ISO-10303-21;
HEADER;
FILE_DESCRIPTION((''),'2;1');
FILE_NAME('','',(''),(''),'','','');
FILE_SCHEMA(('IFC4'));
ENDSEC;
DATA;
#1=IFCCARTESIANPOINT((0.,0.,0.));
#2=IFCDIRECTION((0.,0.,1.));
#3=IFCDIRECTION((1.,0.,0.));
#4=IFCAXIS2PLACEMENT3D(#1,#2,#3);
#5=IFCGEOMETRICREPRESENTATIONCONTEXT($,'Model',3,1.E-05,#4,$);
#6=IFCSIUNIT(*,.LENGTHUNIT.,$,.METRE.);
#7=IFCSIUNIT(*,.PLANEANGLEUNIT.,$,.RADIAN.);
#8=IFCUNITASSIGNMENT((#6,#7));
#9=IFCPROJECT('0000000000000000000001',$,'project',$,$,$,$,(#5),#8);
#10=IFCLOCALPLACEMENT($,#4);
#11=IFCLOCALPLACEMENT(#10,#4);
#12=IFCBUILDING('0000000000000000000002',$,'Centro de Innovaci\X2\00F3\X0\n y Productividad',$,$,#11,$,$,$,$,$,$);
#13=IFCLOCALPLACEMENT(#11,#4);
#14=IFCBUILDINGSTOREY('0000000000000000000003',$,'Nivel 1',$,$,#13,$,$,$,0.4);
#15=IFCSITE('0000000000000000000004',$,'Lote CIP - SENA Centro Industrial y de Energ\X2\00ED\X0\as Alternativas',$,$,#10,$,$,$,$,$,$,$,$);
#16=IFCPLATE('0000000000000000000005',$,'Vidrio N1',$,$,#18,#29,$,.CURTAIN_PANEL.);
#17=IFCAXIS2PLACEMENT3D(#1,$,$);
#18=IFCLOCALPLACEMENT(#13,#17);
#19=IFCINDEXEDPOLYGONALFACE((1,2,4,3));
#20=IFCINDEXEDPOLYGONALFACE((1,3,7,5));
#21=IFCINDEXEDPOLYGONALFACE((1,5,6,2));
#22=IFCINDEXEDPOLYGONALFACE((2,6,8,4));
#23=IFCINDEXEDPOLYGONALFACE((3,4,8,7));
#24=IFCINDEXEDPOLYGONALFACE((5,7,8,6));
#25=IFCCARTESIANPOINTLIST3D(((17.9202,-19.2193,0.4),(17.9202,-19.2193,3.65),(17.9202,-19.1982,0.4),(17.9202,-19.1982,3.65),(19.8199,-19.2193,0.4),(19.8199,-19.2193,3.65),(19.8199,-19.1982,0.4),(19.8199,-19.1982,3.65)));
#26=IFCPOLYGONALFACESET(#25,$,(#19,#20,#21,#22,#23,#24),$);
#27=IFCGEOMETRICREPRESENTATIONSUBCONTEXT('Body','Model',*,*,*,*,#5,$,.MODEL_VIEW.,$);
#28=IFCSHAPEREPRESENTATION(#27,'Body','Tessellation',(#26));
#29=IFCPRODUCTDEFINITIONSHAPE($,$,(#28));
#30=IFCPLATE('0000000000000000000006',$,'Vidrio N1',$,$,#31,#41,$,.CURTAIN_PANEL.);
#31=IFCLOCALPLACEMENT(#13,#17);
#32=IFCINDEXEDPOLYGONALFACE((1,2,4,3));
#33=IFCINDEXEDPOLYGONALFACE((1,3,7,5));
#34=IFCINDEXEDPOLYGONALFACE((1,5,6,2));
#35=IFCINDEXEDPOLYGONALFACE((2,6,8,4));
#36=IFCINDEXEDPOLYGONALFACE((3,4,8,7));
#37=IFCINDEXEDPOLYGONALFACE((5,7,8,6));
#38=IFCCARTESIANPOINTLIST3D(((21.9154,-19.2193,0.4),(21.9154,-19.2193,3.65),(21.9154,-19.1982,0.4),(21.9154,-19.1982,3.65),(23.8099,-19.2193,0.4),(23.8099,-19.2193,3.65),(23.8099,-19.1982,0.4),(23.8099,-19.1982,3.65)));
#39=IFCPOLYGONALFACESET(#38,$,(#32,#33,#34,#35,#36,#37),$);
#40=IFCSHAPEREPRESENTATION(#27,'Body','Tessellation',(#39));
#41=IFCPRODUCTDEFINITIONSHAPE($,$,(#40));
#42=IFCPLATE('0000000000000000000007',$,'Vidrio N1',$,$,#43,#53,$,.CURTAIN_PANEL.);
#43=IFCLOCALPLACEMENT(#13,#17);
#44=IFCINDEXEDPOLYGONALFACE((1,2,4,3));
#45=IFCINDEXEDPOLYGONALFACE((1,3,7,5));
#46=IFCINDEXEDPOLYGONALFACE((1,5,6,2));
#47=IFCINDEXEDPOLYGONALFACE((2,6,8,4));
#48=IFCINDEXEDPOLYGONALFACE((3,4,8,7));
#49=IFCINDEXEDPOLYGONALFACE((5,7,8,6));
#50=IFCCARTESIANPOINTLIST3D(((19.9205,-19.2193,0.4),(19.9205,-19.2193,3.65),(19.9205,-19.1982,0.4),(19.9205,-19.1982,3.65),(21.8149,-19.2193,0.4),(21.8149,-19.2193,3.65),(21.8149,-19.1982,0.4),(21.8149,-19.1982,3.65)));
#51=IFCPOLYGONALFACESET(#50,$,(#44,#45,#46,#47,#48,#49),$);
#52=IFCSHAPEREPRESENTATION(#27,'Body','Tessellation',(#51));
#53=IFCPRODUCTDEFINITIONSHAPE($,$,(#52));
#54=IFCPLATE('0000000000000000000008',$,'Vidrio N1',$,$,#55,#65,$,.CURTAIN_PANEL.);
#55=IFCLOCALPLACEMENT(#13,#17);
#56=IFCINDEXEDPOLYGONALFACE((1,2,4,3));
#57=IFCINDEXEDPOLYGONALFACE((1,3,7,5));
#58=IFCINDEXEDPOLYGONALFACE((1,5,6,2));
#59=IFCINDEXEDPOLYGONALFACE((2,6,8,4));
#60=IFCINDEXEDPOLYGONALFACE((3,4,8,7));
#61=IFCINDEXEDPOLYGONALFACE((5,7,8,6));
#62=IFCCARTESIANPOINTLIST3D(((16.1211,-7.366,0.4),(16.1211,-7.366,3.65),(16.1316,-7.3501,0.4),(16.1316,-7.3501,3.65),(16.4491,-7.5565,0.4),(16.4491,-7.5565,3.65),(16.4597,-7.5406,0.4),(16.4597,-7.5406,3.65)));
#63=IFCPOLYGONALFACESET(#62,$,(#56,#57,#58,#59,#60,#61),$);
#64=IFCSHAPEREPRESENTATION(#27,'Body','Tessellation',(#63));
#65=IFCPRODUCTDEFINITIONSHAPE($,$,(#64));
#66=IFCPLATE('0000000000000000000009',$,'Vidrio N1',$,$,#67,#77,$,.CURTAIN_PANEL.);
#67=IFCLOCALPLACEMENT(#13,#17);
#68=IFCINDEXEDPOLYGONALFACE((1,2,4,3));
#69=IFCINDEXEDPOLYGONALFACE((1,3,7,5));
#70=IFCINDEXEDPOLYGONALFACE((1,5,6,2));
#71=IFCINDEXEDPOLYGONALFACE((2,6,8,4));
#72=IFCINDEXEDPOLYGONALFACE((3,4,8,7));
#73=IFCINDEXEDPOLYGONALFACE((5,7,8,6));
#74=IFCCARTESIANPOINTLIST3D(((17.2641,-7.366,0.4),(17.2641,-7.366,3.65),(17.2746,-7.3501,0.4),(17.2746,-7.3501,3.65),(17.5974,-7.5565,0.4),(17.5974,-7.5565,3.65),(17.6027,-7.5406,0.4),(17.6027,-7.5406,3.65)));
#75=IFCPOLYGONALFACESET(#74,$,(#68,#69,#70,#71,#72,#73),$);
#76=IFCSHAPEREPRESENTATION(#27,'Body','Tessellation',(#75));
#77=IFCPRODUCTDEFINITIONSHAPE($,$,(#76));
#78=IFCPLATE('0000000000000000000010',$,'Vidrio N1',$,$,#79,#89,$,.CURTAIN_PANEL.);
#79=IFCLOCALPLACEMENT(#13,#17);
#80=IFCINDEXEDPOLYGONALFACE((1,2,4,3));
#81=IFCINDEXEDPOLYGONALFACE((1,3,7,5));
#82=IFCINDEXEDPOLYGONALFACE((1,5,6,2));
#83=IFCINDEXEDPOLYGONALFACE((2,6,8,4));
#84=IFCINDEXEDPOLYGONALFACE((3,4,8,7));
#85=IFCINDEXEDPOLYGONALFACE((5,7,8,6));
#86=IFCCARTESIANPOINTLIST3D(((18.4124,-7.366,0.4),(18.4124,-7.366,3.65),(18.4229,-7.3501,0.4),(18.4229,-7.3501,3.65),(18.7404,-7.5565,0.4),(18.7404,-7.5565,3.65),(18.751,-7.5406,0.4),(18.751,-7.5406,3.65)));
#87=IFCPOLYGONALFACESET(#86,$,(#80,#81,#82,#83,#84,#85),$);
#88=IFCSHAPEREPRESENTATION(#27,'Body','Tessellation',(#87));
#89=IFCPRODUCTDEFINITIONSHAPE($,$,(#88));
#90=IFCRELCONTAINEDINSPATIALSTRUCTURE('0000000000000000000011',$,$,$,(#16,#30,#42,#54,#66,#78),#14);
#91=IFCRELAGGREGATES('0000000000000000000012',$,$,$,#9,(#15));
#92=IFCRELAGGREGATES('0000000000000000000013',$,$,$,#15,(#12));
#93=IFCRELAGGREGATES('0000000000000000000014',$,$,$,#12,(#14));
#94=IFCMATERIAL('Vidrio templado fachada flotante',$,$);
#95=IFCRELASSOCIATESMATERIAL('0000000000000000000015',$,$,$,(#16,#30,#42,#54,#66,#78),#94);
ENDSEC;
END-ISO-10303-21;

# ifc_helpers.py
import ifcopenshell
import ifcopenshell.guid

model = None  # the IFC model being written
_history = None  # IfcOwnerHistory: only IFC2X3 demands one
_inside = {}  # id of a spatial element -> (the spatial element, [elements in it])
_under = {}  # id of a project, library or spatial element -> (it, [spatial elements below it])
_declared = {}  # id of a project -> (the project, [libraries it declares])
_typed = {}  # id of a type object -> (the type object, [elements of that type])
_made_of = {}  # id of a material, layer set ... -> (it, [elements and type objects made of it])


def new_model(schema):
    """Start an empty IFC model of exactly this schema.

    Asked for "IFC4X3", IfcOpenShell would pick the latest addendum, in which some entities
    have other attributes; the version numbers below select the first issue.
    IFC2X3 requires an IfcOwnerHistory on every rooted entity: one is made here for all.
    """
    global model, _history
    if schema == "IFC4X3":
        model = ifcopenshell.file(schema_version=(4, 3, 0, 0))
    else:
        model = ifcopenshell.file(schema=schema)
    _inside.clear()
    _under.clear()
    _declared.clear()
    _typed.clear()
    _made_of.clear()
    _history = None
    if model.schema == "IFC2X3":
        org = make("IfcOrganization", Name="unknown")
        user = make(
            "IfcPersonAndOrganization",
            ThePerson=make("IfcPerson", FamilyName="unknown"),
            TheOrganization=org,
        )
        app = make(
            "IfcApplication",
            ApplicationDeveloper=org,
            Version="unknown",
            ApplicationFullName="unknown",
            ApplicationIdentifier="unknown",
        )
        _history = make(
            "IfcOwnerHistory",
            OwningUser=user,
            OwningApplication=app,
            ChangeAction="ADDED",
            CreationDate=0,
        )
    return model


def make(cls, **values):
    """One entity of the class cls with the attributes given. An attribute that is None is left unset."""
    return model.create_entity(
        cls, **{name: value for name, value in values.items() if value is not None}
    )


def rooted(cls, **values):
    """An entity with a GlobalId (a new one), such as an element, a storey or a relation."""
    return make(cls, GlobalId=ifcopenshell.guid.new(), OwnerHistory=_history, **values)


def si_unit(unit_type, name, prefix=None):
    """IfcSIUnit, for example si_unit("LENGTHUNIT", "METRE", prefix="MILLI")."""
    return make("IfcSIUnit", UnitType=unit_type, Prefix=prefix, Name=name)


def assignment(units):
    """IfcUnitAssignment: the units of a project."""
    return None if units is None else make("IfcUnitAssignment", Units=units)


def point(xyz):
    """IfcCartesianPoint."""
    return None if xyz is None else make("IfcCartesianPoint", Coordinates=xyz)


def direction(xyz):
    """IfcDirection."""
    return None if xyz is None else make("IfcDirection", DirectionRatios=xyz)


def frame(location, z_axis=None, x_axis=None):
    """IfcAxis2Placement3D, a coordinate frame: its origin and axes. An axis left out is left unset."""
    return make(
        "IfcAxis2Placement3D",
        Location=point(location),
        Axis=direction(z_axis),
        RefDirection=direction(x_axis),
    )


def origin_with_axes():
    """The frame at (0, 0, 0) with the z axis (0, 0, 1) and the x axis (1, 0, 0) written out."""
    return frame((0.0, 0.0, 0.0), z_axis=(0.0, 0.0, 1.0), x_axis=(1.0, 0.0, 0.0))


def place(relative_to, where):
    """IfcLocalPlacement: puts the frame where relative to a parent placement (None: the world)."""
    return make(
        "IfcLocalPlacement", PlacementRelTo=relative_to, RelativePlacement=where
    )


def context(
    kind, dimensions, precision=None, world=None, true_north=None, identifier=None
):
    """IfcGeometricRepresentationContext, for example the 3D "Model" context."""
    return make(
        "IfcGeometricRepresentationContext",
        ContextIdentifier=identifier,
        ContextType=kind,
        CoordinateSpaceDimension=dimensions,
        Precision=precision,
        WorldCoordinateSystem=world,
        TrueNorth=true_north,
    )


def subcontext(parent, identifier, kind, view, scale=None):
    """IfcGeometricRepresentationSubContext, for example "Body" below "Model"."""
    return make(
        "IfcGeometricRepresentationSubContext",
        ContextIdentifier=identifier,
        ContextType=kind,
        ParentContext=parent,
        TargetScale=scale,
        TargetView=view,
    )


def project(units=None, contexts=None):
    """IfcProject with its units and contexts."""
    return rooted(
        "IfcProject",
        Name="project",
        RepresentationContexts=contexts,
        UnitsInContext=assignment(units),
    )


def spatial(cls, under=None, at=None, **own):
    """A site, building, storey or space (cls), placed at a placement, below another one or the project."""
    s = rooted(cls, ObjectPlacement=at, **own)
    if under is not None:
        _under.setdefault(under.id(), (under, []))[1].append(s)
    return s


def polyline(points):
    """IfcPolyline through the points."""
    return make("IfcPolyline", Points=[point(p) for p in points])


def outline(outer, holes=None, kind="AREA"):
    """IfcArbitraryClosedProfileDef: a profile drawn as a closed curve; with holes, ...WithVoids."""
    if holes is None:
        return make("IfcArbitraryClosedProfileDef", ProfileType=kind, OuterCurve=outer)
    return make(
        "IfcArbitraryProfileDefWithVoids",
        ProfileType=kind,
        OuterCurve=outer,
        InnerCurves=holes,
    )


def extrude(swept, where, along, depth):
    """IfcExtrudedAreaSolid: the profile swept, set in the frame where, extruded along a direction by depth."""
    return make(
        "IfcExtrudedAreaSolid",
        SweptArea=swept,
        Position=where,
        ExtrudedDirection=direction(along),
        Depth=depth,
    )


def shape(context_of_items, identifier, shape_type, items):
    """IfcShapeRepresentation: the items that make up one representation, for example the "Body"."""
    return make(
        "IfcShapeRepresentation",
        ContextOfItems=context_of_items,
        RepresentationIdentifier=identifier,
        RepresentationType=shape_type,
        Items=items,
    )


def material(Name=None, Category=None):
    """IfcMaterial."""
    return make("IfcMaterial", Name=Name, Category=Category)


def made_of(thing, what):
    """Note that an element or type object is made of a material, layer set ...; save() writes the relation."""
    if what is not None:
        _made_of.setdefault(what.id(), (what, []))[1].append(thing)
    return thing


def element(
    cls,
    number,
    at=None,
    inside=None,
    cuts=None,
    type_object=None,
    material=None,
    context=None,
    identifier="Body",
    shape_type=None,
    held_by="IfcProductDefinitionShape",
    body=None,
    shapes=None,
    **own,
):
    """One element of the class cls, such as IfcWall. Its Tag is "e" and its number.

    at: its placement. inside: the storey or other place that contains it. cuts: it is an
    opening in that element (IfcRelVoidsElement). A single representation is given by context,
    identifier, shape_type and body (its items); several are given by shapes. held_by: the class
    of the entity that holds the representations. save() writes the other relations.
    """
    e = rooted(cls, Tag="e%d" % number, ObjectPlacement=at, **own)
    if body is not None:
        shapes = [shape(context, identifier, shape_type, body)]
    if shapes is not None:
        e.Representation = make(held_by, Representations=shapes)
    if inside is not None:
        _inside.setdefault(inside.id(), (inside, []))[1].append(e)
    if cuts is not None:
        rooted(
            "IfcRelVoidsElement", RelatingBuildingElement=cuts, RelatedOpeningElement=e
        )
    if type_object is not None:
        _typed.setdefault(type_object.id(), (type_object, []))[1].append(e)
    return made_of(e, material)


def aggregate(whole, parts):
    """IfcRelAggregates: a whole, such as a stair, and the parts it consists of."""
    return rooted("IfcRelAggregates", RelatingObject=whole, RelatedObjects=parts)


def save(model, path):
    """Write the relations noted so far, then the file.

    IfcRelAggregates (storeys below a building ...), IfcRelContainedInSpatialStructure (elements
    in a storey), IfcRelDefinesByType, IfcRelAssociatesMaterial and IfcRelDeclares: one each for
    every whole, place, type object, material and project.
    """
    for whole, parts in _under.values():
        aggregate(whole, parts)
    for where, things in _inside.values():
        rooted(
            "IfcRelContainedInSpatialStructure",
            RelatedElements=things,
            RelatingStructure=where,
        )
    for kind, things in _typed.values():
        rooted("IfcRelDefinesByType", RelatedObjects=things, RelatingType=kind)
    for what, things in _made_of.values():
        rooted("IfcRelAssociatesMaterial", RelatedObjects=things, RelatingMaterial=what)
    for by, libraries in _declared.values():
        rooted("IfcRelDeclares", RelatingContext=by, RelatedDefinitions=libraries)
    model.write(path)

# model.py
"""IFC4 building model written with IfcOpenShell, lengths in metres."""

from ifc_helpers import new_model, si_unit, frame, origin_with_axes, place, context, subcontext, project, spatial, polyline, outline, extrude, material, element, save


model = new_model("IFC4")

# Units and contexts
model_context = context("Model", 3, precision=1e-05, world=origin_with_axes())
body_context = subcontext(model_context, "Body", "Model", "MODEL_VIEW")
ifc_project = project(units=[si_unit("LENGTHUNIT", "METRE"), si_unit("PLANEANGLEUNIT", "RADIAN")], contexts=[model_context])

# Site, building, storey
site_placement = place(None, origin_with_axes())
site = spatial("IfcSite", under=ifc_project, at=site_placement, Name="Lote CIP - SENA Centro Industrial y de Energías Alternativas")
building_placement = place(site_placement, origin_with_axes())
building = spatial("IfcBuilding", under=site, at=building_placement, Name="Centro de Innovación y Productividad")
storey_placement = place(building_placement, origin_with_axes())
storey = spatial("IfcBuildingStorey", under=building, at=storey_placement, Name="Nivel 1", Elevation=0.4)

# Plates
ifc_material = material(Name="Vidrio templado fachada flotante")
plate_1_placement = place(storey_placement, origin_with_axes())
element("IfcPlate", 1, at=plate_1_placement, inside=storey, material=ifc_material, Name="Vidrio N1", PredefinedType="CURTAIN_PANEL", context=body_context, shape_type="SweptSolid", body=[
    extrude(outline(polyline([(17.9202, -19.2193), (17.9202, -19.1982), (19.8199, -19.1982), (19.8199, -19.2193), (17.9202, -19.2193)])), frame((0.0, 0.0, 0.4)), (0.0, 0.0, 1.0), 3.25),
])
plate_2_placement = place(storey_placement, origin_with_axes())
element("IfcPlate", 2, at=plate_2_placement, inside=storey, material=ifc_material, Name="Vidrio N1", PredefinedType="CURTAIN_PANEL", context=body_context, shape_type="SweptSolid", body=[
    extrude(outline(polyline([(21.9154, -19.1982), (23.8099, -19.1982), (23.8099, -19.2193), (21.9154, -19.2193), (21.9154, -19.1982)])), frame((0.0, 0.0, 0.4)), (0.0, 0.0, 1.0), 3.25),
])
plate_3_placement = place(storey_placement, origin_with_axes())
element("IfcPlate", 3, at=plate_3_placement, inside=storey, material=ifc_material, Name="Vidrio N1", PredefinedType="CURTAIN_PANEL", context=body_context, shape_type="SweptSolid", body=[
    extrude(outline(polyline([(21.8149, -19.1982), (21.8149, -19.2193), (19.9205, -19.2193), (19.9205, -19.1982), (21.8149, -19.1982)])), frame((0.0, 0.0, 0.4)), (0.0, 0.0, 1.0), 3.25),
])
plate_4_placement = place(storey_placement, origin_with_axes())
element("IfcPlate", 4, at=plate_4_placement, inside=storey, material=ifc_material, Name="Vidrio N1", PredefinedType="CURTAIN_PANEL", context=body_context, shape_type="SweptSolid", body=[
    extrude(outline(polyline([(16.1211, -7.366), (16.1316, -7.3501), (16.4597, -7.5406), (16.4491, -7.5565), (16.1211, -7.366)])), frame((0.0, 0.0, 0.4)), (0.0, 0.0, 1.0), 3.25),
])
plate_5_placement = place(storey_placement, origin_with_axes())
element("IfcPlate", 5, at=plate_5_placement, inside=storey, material=ifc_material, Name="Vidrio N1", PredefinedType="CURTAIN_PANEL", context=body_context, shape_type="SweptSolid", body=[
    extrude(outline(polyline([(17.2641, -7.366), (17.2746, -7.3501), (17.6027, -7.5406), (17.5974, -7.5565), (17.2641, -7.366)])), frame((0.0, 0.0, 0.4)), (0.0, 0.0, 1.0), 3.25),
])
plate_6_placement = place(storey_placement, origin_with_axes())
element("IfcPlate", 6, at=plate_6_placement, inside=storey, material=ifc_material, Name="Vidrio N1", PredefinedType="CURTAIN_PANEL", context=body_context, shape_type="SweptSolid", body=[
    extrude(outline(polyline([(18.4229, -7.3501), (18.751, -7.5406), (18.7404, -7.5565), (18.4124, -7.366), (18.4229, -7.3501)])), frame((0.0, 0.0, 0.4)), (0.0, 0.0, 1.0), 3.25),
])

save(model, "model.ifc")
